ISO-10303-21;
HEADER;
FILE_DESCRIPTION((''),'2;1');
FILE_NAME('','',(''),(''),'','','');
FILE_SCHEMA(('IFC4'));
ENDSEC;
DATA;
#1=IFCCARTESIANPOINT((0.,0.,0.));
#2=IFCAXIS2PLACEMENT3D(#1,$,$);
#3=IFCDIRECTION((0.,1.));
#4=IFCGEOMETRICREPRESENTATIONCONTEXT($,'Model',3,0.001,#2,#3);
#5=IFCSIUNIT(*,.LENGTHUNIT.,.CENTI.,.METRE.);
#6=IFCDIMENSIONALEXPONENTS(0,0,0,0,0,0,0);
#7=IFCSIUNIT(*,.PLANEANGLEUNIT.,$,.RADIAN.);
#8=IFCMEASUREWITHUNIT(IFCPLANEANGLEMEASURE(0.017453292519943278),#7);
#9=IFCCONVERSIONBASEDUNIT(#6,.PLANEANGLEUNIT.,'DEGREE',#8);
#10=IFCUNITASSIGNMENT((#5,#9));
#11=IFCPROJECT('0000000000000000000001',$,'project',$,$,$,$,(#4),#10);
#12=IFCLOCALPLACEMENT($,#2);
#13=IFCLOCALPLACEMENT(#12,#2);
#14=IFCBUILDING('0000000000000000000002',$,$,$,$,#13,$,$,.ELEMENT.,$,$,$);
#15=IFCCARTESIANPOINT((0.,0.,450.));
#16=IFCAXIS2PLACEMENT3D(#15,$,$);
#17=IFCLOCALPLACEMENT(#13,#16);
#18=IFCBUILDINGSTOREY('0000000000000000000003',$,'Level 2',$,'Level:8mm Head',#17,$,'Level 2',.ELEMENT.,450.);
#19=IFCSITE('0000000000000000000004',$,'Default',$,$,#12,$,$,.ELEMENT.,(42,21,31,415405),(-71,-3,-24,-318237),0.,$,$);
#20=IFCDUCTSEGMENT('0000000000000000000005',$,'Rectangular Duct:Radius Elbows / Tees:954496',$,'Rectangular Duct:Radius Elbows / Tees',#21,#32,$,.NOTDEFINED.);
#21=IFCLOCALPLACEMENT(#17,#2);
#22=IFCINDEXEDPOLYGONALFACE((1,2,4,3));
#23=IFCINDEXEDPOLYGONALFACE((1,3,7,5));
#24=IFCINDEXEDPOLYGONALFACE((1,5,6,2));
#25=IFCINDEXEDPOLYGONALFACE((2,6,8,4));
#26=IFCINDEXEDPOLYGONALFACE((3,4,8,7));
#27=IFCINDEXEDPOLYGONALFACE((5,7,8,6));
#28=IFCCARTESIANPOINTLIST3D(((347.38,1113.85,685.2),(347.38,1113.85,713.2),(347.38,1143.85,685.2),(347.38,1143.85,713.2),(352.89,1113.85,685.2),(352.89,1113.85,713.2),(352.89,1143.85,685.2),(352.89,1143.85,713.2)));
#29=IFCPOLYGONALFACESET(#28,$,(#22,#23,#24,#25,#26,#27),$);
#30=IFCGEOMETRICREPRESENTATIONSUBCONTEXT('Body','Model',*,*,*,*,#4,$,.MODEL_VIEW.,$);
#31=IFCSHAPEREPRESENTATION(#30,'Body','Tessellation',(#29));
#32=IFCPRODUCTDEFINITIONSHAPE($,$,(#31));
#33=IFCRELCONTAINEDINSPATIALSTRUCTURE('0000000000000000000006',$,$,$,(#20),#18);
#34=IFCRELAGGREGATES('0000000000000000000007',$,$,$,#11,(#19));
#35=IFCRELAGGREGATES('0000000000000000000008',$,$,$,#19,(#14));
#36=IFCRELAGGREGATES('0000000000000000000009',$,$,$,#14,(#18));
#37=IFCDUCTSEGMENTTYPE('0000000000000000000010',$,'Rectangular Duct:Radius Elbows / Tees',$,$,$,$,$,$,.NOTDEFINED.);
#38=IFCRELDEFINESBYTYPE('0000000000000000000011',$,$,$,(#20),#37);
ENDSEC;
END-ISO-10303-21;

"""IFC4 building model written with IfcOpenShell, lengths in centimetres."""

from ifc_helpers import new_model, entity, si_unit, converted_unit, direction, frame, origin, place, context, subcontext, project, spatial, indexed_curve, outline, extrude, type_object, element, save


model = new_model("IFC4")

# Units and contexts
model_context = context("Model", 3, precision=0.001, world=origin(), true_north=direction((0.0, 1.0)))
body_context = subcontext(model_context, "Body", "Model", "MODEL_VIEW")
ifc_project = project(units=[si_unit("LENGTHUNIT", "METRE", prefix="CENTI"), converted_unit("PLANEANGLEUNIT", "DEGREE", entity("IfcPlaneAngleMeasure", 0.017453292519943278), si_unit("PLANEANGLEUNIT", "RADIAN"), dimensions=[0, 0, 0, 0, 0, 0, 0])], contexts=[model_context])

# Site, building, storey
site_placement = place(None, origin())
site = spatial("IfcSite", under=ifc_project, at=site_placement, Name="Default", CompositionType="ELEMENT", RefLatitude=(42, 21, 31, 415405), RefLongitude=(-71, -3, -24, -318237), RefElevation=0.0)
building_placement = place(site_placement, origin())
building = spatial("IfcBuilding", under=site, at=building_placement, CompositionType="ELEMENT")
storey_placement = place(building_placement, frame((0.0, 0.0, 450.0)))
storey = spatial("IfcBuildingStorey", under=building, at=storey_placement, Name="Level 2", ObjectType="Level:8mm Head", LongName="Level 2", CompositionType="ELEMENT", Elevation=450.0)

# Duct segment
duct_segment_type = type_object("IfcDuctSegmentType", Name="Rectangular Duct:Radius Elbows / Tees", PredefinedType="NOTDEFINED")
duct_segment_1_placement = place(storey_placement, origin())
element("IfcDuctSegment", 1, at=duct_segment_1_placement, inside=storey, type_object=duct_segment_type, Name="Rectangular Duct:Radius Elbows / Tees:954496", ObjectType="Rectangular Duct:Radius Elbows / Tees", PredefinedType="NOTDEFINED", context=body_context, shape_type="SweptSolid", body=[
    extrude(outline(indexed_curve([(-2.76, -15.0), (2.76, -15.0), (2.76, 15.0), (-2.76, 15.0), (-2.76, -15.0)], self_intersect=False)), frame((350.13, 1128.85, 685.2), z_axis=(0.0, 0.0, 1.0), x_axis=(-1.0, 0.0, 0.0)), (0.0, 0.0, 1.0), 28.0),
])

save(model, "model.ifc")
